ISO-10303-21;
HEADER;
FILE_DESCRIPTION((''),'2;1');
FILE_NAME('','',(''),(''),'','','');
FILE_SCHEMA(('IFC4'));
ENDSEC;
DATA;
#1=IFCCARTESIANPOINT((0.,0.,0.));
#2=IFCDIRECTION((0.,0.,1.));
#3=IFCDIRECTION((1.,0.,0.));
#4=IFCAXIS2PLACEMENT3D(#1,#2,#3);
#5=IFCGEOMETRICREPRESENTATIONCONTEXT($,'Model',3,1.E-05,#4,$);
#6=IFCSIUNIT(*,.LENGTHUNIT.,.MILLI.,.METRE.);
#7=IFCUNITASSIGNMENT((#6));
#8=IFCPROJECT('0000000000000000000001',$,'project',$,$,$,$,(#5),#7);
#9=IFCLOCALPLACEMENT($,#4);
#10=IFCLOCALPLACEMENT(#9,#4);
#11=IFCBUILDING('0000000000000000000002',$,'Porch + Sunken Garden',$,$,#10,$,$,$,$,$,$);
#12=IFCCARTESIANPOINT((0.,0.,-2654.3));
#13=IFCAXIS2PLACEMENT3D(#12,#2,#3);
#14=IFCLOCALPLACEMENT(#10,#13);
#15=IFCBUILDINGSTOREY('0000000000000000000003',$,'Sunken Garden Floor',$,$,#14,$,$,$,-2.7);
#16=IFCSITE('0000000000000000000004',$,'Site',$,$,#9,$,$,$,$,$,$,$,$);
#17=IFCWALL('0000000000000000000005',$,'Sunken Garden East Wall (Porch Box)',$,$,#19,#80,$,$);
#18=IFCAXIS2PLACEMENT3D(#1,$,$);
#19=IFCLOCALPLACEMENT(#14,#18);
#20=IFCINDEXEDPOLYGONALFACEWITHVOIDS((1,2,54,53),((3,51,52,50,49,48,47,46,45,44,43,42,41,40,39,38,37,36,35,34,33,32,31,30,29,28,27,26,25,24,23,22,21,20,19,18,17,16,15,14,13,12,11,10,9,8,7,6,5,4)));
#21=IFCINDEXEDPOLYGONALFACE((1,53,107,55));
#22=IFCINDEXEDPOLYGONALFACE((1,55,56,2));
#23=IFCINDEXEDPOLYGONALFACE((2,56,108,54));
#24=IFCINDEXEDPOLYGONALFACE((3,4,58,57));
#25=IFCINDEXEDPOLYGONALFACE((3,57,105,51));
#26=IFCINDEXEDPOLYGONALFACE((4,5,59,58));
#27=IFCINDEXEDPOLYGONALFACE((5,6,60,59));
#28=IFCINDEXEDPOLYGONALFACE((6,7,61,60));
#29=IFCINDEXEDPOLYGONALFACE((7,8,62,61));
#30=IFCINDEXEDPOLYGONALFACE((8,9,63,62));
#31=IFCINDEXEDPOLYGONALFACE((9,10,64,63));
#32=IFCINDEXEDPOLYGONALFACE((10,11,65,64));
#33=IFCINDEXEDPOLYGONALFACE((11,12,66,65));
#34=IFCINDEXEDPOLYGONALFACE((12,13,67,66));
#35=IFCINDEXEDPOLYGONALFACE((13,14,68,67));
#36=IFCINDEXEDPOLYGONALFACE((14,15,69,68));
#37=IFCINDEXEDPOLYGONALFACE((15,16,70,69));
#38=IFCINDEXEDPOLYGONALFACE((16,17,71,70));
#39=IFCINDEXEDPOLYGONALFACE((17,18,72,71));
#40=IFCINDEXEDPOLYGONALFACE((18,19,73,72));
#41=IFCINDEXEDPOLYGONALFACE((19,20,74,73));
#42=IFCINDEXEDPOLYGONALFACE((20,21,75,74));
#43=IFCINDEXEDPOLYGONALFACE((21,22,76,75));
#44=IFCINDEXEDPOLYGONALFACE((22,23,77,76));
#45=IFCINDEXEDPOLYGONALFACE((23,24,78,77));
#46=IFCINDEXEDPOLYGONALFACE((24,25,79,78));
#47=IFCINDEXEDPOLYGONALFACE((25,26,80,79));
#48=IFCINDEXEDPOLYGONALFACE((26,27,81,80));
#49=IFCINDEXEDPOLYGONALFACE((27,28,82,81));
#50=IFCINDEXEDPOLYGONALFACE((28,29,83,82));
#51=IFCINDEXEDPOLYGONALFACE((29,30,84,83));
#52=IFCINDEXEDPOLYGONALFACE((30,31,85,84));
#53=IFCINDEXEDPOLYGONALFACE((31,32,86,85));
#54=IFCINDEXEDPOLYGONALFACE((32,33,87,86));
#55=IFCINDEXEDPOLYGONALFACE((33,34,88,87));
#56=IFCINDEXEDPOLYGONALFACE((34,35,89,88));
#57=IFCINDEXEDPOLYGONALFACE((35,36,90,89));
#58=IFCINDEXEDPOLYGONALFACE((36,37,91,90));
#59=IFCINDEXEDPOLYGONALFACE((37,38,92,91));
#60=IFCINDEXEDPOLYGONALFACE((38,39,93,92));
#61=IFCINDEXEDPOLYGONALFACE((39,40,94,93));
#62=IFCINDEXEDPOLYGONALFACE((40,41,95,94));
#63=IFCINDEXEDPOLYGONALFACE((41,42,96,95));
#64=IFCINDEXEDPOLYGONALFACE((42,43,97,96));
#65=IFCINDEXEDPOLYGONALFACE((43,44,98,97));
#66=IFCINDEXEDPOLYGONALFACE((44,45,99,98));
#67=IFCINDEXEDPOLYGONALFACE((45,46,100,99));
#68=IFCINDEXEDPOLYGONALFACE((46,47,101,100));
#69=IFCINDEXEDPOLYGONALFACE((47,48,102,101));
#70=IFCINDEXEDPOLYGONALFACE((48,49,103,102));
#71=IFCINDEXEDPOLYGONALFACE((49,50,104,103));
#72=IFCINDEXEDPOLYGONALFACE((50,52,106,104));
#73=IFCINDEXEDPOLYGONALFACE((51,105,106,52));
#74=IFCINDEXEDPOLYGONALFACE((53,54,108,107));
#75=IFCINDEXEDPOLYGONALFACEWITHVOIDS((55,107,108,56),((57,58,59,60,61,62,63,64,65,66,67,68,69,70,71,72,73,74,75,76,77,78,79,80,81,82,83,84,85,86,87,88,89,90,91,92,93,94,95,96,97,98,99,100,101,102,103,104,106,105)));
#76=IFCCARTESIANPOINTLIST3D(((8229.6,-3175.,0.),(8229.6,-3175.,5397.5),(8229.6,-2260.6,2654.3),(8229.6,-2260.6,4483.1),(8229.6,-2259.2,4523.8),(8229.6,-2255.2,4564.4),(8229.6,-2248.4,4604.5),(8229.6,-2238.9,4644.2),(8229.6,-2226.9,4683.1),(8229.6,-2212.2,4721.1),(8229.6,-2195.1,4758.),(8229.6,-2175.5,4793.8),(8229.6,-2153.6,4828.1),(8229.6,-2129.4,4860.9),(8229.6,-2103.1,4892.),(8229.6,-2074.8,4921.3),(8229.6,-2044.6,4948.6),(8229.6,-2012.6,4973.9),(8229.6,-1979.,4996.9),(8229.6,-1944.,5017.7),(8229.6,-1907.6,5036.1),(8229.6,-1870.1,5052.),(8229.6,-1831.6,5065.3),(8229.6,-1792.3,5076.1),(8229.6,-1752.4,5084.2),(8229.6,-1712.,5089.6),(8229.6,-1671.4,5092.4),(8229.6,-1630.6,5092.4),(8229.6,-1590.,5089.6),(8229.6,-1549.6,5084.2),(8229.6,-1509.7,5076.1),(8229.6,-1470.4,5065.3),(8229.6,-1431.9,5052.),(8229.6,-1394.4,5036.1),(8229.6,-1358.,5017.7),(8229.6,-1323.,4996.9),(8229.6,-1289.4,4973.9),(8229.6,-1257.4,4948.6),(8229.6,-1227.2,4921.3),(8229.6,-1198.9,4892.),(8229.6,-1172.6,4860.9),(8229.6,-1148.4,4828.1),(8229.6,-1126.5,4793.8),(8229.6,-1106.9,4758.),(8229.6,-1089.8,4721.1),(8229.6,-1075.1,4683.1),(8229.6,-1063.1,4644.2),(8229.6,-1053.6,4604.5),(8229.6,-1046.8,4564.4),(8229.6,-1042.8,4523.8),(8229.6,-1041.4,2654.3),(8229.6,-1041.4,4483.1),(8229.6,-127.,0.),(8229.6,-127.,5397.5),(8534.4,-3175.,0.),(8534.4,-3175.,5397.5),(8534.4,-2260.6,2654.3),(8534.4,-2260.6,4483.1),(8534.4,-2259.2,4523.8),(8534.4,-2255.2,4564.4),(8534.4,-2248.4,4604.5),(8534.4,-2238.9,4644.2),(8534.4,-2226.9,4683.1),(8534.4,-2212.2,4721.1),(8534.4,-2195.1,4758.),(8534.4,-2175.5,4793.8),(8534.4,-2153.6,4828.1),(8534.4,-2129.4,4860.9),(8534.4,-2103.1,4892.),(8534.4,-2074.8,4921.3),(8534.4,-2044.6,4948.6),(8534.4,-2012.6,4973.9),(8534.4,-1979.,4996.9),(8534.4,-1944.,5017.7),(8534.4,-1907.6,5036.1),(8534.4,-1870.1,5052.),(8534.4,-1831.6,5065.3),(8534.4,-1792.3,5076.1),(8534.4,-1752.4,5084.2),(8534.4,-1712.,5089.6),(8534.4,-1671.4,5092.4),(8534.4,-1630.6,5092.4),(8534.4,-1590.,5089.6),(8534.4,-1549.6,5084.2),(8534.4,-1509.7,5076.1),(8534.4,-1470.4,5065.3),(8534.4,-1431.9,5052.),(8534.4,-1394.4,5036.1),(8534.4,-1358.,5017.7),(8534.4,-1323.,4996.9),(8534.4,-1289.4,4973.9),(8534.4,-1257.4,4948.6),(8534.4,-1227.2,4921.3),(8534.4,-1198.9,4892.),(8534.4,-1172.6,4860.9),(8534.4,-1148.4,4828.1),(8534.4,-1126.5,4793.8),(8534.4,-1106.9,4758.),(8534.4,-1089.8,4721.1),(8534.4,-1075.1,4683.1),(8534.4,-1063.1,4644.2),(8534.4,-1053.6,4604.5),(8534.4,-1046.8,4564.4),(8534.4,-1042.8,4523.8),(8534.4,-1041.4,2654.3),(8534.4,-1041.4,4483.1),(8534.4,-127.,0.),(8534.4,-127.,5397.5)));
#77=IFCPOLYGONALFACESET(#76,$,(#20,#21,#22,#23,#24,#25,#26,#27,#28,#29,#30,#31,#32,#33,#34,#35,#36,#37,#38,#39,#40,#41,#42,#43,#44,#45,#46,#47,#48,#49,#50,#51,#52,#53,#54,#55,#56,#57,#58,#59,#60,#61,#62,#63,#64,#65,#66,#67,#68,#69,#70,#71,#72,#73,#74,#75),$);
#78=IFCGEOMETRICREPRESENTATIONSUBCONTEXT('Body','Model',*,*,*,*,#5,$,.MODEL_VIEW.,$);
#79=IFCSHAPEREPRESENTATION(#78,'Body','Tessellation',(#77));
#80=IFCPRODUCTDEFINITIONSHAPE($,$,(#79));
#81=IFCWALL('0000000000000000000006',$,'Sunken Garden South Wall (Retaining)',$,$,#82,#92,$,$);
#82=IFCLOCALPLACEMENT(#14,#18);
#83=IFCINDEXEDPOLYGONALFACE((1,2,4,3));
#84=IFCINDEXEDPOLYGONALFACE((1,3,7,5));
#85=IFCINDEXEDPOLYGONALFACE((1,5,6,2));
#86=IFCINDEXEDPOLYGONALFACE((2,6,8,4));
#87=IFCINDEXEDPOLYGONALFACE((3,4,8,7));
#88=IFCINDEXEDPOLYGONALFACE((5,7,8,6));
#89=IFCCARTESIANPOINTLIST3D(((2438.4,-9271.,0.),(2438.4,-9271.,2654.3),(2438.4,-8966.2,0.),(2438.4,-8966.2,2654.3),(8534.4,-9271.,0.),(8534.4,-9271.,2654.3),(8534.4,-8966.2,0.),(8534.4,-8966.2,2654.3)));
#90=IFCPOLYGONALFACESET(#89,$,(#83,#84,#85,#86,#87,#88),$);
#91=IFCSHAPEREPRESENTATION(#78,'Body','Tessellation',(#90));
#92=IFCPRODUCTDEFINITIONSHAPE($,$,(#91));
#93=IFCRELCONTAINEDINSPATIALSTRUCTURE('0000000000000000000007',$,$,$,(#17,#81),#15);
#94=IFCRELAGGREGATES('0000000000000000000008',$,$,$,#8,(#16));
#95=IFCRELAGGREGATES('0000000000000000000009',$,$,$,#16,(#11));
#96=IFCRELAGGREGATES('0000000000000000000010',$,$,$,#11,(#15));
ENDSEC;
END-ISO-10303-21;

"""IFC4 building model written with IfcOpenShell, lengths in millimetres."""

from ifc_helpers import new_model, si_unit, frame, origin_with_axes, place, context, subcontext, project, spatial, indexed_curve, outline, extrude, element, save


model = new_model("IFC4")

# Units and contexts
model_context = context("Model", 3, precision=1e-05, world=origin_with_axes())
body_context = subcontext(model_context, "Body", "Model", "MODEL_VIEW")
ifc_project = project(units=[si_unit("LENGTHUNIT", "METRE", prefix="MILLI")], contexts=[model_context])

# Site, building, storey
site_placement = place(None, origin_with_axes())
site = spatial("IfcSite", under=ifc_project, at=site_placement, Name="Site")
building_placement = place(site_placement, origin_with_axes())
building = spatial("IfcBuilding", under=site, at=building_placement, Name="Porch + Sunken Garden")
storey_placement = place(building_placement, frame((0.0, 0.0, -2654.3), z_axis=(0.0, 0.0, 1.0), x_axis=(1.0, 0.0, 0.0)))
storey = spatial("IfcBuildingStorey", under=building, at=storey_placement, Name="Sunken Garden Floor", Elevation=-2.7)

# Walls
wall_1_placement = place(storey_placement, frame((8229.6, -127.0, 0.0), z_axis=(1.0, 0.0, 0.0), x_axis=(0.0, -1.0, 0.0)))
element("IfcWall", 1, at=wall_1_placement, inside=storey, Name="Sunken Garden East Wall (Porch Box)", context=body_context, shape_type="SweptSolid", body=[
    extrude(outline(indexed_curve([(0.0, 0.0), (3048.0, 0.0), (3048.0, -5397.5), (0.0, -5397.5), (0.0, 0.0)]), holes=[indexed_curve([(914.4, -2654.3), (914.4, -4483.1), (914.4, -4483.1), (915.8, -4523.8), (919.8, -4564.4), (926.6, -4604.5), (936.1, -4644.2), (948.1, -4683.1), (962.8, -4721.1), (979.9, -4758.0), (999.5, -4793.8), (1021.4, -4828.1), (1045.6, -4860.9), (1071.9, -4892.0), (1100.2, -4921.3), (1130.4, -4948.6), (1162.4, -4973.9), (1196.0, -4996.9), (1231.0, -5017.7), (1267.4, -5036.1), (1304.9, -5052.0), (1343.4, -5065.3), (1382.7, -5076.1), (1422.6, -5084.2), (1463.0, -5089.6), (1503.6, -5092.4), (1544.4, -5092.4), (1585.0, -5089.6), (1625.4, -5084.2), (1665.3, -5076.1), (1704.6, -5065.3), (1743.1, -5052.0), (1780.6, -5036.1), (1817.0, -5017.7), (1852.0, -4996.9), (1885.6, -4973.9), (1917.6, -4948.6), (1947.8, -4921.3), (1976.1, -4892.0), (2002.4, -4860.9), (2026.6, -4828.1), (2048.5, -4793.8), (2068.1, -4758.0), (2085.2, -4721.1), (2099.9, -4683.1), (2111.9, -4644.2), (2121.4, -4604.5), (2128.2, -4564.4), (2132.2, -4523.8), (2133.6, -4483.1), (2133.6, -2654.3), (914.4, -2654.3)])]), origin_with_axes(), (0.0, 0.0, 1.0), 304.8),
])
wall_2_placement = place(storey_placement, frame((2438.4, -9271.0, 0.0), z_axis=(0.0, 0.0, 1.0), x_axis=(1.0, 0.0, 0.0)))
element("IfcWall", 2, at=wall_2_placement, inside=storey, Name="Sunken Garden South Wall (Retaining)", context=body_context, shape_type="SweptSolid", body=[
    extrude(outline(indexed_curve([(0.0, 0.0), (6096.0, 0.0), (6096.0, 304.8), (0.0, 304.8), (0.0, 0.0)])), origin_with_axes(), (0.0, 0.0, 1.0), 2654.3),
])

save(model, "model.ifc")
